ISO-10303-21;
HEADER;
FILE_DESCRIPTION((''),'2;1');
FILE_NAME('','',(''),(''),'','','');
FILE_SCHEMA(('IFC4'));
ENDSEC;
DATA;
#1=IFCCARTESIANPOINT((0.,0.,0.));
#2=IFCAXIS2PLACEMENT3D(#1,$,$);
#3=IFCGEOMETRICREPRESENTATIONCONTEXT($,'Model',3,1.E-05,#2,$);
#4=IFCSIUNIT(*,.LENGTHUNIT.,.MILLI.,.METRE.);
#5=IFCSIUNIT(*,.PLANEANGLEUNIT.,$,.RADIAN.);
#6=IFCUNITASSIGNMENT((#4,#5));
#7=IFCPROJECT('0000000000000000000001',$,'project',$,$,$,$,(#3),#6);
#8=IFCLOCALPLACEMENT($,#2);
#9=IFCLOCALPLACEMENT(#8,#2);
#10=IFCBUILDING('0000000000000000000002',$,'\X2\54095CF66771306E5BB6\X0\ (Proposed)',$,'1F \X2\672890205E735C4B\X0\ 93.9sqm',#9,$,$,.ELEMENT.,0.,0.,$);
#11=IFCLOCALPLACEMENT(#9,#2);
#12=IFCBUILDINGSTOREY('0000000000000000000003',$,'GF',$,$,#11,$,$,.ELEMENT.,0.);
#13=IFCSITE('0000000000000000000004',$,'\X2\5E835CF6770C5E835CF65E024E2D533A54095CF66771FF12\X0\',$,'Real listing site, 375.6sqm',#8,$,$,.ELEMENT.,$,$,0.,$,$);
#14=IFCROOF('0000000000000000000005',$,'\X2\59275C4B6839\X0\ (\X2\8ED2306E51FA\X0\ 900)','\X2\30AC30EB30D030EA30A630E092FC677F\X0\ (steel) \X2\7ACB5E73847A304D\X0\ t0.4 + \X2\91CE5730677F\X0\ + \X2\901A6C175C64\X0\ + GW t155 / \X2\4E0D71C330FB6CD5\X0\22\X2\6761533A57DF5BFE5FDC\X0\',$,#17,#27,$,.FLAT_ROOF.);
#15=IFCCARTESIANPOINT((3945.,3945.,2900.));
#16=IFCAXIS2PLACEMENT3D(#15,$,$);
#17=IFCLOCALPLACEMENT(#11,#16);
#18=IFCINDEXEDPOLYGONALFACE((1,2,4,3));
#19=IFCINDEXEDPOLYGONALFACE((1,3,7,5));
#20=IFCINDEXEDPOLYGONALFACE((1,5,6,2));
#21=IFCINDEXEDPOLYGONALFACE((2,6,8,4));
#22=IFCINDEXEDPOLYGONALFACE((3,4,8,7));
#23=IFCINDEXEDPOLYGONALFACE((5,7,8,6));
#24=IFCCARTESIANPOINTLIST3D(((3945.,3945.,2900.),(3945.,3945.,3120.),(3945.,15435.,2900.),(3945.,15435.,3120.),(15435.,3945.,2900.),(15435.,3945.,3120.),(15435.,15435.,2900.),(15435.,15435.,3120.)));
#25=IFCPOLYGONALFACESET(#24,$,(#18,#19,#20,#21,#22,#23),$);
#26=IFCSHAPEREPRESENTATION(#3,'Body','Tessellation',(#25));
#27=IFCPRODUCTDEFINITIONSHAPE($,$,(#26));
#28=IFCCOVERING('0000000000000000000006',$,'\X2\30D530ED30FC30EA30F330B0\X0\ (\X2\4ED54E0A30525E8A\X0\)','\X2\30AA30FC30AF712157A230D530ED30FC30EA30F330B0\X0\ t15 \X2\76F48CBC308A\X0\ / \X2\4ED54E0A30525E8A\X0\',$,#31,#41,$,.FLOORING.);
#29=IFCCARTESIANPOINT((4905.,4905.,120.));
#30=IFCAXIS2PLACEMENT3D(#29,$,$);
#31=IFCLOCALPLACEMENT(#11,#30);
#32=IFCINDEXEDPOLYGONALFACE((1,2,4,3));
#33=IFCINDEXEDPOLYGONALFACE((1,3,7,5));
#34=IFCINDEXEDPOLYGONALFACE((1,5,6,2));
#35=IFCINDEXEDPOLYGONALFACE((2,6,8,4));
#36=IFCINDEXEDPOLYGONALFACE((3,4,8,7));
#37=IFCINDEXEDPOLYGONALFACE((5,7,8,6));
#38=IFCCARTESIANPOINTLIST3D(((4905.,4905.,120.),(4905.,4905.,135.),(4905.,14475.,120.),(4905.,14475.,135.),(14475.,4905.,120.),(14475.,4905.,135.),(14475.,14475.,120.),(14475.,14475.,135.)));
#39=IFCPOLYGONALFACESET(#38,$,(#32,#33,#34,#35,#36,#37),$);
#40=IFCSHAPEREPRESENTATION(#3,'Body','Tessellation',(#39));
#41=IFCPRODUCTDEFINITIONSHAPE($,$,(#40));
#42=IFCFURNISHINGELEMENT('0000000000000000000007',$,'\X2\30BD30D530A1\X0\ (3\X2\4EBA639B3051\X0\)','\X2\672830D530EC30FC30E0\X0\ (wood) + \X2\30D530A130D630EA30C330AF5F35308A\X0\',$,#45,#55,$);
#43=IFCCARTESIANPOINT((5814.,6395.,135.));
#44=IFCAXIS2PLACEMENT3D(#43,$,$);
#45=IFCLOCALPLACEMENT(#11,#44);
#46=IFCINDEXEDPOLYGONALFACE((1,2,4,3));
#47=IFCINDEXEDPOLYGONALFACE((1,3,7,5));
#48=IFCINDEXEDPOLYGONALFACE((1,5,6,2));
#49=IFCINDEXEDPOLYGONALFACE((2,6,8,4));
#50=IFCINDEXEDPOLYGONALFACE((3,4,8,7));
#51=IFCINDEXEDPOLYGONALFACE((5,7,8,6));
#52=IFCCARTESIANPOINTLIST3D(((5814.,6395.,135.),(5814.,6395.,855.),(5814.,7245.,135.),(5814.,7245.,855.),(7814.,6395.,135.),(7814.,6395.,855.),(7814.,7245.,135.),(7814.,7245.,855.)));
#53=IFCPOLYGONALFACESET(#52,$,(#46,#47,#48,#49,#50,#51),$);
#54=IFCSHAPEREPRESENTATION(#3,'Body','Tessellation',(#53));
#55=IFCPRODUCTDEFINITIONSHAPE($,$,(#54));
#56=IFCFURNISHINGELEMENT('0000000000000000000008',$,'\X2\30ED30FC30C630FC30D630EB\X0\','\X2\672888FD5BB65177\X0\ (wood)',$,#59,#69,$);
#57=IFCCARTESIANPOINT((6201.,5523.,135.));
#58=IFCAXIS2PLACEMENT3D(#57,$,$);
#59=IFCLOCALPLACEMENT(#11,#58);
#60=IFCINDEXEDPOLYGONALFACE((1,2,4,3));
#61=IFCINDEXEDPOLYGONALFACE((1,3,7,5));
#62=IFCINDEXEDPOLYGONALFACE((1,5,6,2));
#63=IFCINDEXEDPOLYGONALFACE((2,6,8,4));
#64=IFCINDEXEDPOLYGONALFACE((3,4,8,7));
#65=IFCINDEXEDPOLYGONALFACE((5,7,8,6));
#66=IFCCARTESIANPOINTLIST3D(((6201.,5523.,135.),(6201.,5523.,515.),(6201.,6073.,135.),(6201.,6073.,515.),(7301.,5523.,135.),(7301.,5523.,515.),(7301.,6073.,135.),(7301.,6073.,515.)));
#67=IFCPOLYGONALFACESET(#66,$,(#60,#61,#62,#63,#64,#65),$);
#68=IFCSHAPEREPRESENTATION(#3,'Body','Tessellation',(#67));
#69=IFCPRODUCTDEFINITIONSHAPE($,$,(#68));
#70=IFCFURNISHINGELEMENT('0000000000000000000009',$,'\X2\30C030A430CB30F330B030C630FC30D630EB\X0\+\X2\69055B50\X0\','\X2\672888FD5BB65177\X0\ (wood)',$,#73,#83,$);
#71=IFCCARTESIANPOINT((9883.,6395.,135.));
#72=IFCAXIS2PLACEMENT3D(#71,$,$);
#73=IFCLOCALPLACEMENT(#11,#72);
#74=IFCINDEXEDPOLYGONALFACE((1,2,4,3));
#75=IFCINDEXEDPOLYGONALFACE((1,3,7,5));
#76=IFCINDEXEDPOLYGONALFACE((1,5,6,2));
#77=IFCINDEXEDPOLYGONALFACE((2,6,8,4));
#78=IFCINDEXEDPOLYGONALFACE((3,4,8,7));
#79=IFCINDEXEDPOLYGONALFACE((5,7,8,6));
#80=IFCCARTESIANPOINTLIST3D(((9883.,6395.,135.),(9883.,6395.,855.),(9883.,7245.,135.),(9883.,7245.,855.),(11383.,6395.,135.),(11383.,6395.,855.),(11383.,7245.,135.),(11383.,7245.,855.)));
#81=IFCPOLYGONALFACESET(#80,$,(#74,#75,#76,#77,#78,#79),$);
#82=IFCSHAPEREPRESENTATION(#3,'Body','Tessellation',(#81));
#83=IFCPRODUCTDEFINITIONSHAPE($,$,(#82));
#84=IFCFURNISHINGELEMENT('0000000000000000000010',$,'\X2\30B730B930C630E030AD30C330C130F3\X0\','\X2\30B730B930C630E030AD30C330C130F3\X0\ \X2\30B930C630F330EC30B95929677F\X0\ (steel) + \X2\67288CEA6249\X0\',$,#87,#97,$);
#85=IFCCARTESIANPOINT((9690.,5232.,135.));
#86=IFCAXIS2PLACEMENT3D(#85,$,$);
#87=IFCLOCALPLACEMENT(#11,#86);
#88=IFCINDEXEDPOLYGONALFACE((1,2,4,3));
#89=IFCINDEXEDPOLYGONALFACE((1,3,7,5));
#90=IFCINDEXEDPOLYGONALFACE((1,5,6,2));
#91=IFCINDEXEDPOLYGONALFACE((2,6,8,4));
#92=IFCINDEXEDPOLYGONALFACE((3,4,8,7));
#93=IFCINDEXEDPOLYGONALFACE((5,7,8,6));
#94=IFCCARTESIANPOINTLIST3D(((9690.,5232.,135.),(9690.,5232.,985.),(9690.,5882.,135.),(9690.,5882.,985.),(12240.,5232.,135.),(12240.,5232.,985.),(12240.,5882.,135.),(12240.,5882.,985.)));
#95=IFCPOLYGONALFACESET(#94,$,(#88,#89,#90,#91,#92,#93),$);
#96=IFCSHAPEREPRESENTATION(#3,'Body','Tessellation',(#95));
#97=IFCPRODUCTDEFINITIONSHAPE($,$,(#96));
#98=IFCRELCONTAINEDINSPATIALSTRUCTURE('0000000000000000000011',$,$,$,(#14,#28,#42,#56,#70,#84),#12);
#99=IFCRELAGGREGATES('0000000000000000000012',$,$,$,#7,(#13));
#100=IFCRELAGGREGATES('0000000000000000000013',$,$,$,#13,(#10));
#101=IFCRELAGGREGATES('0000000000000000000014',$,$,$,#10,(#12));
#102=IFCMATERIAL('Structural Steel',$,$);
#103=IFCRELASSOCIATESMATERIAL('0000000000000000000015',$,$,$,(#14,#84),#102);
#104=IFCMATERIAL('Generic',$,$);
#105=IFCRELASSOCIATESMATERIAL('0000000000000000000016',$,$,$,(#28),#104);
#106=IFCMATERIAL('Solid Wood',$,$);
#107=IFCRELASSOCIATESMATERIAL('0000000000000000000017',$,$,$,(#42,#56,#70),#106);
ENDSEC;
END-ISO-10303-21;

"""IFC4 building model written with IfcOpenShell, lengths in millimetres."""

from ifc_helpers import new_model, si_unit, frame, frame_2d, origin, place, context, project, spatial, rectangle, extrude, material, element, save


model = new_model("IFC4")

# Units and contexts
model_context = context("Model", 3, precision=1e-05, world=origin())
ifc_project = project(units=[si_unit("LENGTHUNIT", "METRE", prefix="MILLI"), si_unit("PLANEANGLEUNIT", "RADIAN")], contexts=[model_context])

# Site, building, storey
site_placement = place(None, origin())
site = spatial("IfcSite", under=ifc_project, at=site_placement, Name="広島県広島市中区吉島東２", ObjectType="Real listing site, 375.6sqm", CompositionType="ELEMENT", RefElevation=0.0)
building_placement = place(site_placement, origin())
building = spatial("IfcBuilding", under=site, at=building_placement, Name="吉島東の家 (Proposed)", ObjectType="1F 木造平屋 93.9sqm", CompositionType="ELEMENT", ElevationOfRefHeight=0.0, ElevationOfTerrain=0.0)
storey_placement = place(building_placement, origin())
storey = spatial("IfcBuildingStorey", under=building, at=storey_placement, Name="GF", CompositionType="ELEMENT", Elevation=0.0)

# Shared definitions
ifc_material_1 = material(Name="Solid Wood")

# Roof
ifc_material_2 = material(Name="Structural Steel")
roof_placement = place(storey_placement, frame((3945.0, 3945.0, 2900.0)))
element("IfcRoof", 1, at=roof_placement, inside=storey, material=ifc_material_2, Name="大屋根 (軒の出 900)", Description="ガルバリウム鋼板 (steel) 立平葺き t0.4 + 野地板 + 通気層 + GW t155 / 不燃・法22条区域対応", PredefinedType="FLAT_ROOF", context=model_context, shape_type="SweptSolid", body=[
    extrude(rectangle(XDim=11490.0, YDim=11490.0, at=frame_2d((5745.0, 5745.0))), frame((3945.0, 3945.0, 2900.0)), (0.0, 0.0, 1.0), 220.0),
])

# Covering
ifc_material_3 = material(Name="Generic")
covering_placement = place(storey_placement, frame((4905.0, 4905.0, 120.0)))
element("IfcCovering", 2, at=covering_placement, inside=storey, material=ifc_material_3, Name="フローリング (仕上げ床)", Description="オーク無垢フローリング t15 直貼り / 仕上げ床", PredefinedType="FLOORING", context=model_context, shape_type="SweptSolid", body=[
    extrude(rectangle(XDim=9570.0, YDim=9570.0, at=frame_2d((4785.0, 4785.0))), frame((4905.0, 4905.0, 120.0)), (0.0, 0.0, 1.0), 15.0),
])

# Furnishing elements
furnishing_1_placement = place(storey_placement, frame((5814.0, 6395.0, 135.0)))
element("IfcFurnishingElement", 3, at=furnishing_1_placement, inside=storey, material=ifc_material_1, Name="ソファ (3人掛け)", Description="木フレーム (wood) + ファブリック張り", context=model_context, shape_type="SweptSolid", body=[
    extrude(rectangle(XDim=2000.0, YDim=850.0, at=frame_2d((1000.0, 425.0))), frame((5814.0, 6395.0, 135.0)), (0.0, 0.0, 1.0), 720.0),
])
furnishing_2_placement = place(storey_placement, frame((6201.0, 5523.0, 135.0)))
element("IfcFurnishingElement", 4, at=furnishing_2_placement, inside=storey, material=ifc_material_1, Name="ローテーブル", Description="木製家具 (wood)", context=model_context, shape_type="SweptSolid", body=[
    extrude(rectangle(XDim=1100.0, YDim=550.0, at=frame_2d((550.0, 275.0))), frame((6201.0, 5523.0, 135.0)), (0.0, 0.0, 1.0), 380.0),
])
furnishing_3_placement = place(storey_placement, frame((9883.0, 6395.0, 135.0)))
element("IfcFurnishingElement", 5, at=furnishing_3_placement, inside=storey, material=ifc_material_1, Name="ダイニングテーブル+椅子", Description="木製家具 (wood)", context=model_context, shape_type="SweptSolid", body=[
    extrude(rectangle(XDim=1500.0, YDim=850.0, at=frame_2d((750.0, 425.0))), frame((9883.0, 6395.0, 135.0)), (0.0, 0.0, 1.0), 720.0),
])
furnishing_4_placement = place(storey_placement, frame((9690.0, 5232.0, 135.0)))
element("IfcFurnishingElement", 6, at=furnishing_4_placement, inside=storey, material=ifc_material_2, Name="システムキッチン", Description="システムキッチン ステンレス天板 (steel) + 木質扉", context=model_context, shape_type="SweptSolid", body=[
    extrude(rectangle(XDim=2550.0, YDim=650.0, at=frame_2d((1275.0, 325.0))), frame((9690.0, 5232.0, 135.0)), (0.0, 0.0, 1.0), 850.0),
])

save(model, "model.ifc")
